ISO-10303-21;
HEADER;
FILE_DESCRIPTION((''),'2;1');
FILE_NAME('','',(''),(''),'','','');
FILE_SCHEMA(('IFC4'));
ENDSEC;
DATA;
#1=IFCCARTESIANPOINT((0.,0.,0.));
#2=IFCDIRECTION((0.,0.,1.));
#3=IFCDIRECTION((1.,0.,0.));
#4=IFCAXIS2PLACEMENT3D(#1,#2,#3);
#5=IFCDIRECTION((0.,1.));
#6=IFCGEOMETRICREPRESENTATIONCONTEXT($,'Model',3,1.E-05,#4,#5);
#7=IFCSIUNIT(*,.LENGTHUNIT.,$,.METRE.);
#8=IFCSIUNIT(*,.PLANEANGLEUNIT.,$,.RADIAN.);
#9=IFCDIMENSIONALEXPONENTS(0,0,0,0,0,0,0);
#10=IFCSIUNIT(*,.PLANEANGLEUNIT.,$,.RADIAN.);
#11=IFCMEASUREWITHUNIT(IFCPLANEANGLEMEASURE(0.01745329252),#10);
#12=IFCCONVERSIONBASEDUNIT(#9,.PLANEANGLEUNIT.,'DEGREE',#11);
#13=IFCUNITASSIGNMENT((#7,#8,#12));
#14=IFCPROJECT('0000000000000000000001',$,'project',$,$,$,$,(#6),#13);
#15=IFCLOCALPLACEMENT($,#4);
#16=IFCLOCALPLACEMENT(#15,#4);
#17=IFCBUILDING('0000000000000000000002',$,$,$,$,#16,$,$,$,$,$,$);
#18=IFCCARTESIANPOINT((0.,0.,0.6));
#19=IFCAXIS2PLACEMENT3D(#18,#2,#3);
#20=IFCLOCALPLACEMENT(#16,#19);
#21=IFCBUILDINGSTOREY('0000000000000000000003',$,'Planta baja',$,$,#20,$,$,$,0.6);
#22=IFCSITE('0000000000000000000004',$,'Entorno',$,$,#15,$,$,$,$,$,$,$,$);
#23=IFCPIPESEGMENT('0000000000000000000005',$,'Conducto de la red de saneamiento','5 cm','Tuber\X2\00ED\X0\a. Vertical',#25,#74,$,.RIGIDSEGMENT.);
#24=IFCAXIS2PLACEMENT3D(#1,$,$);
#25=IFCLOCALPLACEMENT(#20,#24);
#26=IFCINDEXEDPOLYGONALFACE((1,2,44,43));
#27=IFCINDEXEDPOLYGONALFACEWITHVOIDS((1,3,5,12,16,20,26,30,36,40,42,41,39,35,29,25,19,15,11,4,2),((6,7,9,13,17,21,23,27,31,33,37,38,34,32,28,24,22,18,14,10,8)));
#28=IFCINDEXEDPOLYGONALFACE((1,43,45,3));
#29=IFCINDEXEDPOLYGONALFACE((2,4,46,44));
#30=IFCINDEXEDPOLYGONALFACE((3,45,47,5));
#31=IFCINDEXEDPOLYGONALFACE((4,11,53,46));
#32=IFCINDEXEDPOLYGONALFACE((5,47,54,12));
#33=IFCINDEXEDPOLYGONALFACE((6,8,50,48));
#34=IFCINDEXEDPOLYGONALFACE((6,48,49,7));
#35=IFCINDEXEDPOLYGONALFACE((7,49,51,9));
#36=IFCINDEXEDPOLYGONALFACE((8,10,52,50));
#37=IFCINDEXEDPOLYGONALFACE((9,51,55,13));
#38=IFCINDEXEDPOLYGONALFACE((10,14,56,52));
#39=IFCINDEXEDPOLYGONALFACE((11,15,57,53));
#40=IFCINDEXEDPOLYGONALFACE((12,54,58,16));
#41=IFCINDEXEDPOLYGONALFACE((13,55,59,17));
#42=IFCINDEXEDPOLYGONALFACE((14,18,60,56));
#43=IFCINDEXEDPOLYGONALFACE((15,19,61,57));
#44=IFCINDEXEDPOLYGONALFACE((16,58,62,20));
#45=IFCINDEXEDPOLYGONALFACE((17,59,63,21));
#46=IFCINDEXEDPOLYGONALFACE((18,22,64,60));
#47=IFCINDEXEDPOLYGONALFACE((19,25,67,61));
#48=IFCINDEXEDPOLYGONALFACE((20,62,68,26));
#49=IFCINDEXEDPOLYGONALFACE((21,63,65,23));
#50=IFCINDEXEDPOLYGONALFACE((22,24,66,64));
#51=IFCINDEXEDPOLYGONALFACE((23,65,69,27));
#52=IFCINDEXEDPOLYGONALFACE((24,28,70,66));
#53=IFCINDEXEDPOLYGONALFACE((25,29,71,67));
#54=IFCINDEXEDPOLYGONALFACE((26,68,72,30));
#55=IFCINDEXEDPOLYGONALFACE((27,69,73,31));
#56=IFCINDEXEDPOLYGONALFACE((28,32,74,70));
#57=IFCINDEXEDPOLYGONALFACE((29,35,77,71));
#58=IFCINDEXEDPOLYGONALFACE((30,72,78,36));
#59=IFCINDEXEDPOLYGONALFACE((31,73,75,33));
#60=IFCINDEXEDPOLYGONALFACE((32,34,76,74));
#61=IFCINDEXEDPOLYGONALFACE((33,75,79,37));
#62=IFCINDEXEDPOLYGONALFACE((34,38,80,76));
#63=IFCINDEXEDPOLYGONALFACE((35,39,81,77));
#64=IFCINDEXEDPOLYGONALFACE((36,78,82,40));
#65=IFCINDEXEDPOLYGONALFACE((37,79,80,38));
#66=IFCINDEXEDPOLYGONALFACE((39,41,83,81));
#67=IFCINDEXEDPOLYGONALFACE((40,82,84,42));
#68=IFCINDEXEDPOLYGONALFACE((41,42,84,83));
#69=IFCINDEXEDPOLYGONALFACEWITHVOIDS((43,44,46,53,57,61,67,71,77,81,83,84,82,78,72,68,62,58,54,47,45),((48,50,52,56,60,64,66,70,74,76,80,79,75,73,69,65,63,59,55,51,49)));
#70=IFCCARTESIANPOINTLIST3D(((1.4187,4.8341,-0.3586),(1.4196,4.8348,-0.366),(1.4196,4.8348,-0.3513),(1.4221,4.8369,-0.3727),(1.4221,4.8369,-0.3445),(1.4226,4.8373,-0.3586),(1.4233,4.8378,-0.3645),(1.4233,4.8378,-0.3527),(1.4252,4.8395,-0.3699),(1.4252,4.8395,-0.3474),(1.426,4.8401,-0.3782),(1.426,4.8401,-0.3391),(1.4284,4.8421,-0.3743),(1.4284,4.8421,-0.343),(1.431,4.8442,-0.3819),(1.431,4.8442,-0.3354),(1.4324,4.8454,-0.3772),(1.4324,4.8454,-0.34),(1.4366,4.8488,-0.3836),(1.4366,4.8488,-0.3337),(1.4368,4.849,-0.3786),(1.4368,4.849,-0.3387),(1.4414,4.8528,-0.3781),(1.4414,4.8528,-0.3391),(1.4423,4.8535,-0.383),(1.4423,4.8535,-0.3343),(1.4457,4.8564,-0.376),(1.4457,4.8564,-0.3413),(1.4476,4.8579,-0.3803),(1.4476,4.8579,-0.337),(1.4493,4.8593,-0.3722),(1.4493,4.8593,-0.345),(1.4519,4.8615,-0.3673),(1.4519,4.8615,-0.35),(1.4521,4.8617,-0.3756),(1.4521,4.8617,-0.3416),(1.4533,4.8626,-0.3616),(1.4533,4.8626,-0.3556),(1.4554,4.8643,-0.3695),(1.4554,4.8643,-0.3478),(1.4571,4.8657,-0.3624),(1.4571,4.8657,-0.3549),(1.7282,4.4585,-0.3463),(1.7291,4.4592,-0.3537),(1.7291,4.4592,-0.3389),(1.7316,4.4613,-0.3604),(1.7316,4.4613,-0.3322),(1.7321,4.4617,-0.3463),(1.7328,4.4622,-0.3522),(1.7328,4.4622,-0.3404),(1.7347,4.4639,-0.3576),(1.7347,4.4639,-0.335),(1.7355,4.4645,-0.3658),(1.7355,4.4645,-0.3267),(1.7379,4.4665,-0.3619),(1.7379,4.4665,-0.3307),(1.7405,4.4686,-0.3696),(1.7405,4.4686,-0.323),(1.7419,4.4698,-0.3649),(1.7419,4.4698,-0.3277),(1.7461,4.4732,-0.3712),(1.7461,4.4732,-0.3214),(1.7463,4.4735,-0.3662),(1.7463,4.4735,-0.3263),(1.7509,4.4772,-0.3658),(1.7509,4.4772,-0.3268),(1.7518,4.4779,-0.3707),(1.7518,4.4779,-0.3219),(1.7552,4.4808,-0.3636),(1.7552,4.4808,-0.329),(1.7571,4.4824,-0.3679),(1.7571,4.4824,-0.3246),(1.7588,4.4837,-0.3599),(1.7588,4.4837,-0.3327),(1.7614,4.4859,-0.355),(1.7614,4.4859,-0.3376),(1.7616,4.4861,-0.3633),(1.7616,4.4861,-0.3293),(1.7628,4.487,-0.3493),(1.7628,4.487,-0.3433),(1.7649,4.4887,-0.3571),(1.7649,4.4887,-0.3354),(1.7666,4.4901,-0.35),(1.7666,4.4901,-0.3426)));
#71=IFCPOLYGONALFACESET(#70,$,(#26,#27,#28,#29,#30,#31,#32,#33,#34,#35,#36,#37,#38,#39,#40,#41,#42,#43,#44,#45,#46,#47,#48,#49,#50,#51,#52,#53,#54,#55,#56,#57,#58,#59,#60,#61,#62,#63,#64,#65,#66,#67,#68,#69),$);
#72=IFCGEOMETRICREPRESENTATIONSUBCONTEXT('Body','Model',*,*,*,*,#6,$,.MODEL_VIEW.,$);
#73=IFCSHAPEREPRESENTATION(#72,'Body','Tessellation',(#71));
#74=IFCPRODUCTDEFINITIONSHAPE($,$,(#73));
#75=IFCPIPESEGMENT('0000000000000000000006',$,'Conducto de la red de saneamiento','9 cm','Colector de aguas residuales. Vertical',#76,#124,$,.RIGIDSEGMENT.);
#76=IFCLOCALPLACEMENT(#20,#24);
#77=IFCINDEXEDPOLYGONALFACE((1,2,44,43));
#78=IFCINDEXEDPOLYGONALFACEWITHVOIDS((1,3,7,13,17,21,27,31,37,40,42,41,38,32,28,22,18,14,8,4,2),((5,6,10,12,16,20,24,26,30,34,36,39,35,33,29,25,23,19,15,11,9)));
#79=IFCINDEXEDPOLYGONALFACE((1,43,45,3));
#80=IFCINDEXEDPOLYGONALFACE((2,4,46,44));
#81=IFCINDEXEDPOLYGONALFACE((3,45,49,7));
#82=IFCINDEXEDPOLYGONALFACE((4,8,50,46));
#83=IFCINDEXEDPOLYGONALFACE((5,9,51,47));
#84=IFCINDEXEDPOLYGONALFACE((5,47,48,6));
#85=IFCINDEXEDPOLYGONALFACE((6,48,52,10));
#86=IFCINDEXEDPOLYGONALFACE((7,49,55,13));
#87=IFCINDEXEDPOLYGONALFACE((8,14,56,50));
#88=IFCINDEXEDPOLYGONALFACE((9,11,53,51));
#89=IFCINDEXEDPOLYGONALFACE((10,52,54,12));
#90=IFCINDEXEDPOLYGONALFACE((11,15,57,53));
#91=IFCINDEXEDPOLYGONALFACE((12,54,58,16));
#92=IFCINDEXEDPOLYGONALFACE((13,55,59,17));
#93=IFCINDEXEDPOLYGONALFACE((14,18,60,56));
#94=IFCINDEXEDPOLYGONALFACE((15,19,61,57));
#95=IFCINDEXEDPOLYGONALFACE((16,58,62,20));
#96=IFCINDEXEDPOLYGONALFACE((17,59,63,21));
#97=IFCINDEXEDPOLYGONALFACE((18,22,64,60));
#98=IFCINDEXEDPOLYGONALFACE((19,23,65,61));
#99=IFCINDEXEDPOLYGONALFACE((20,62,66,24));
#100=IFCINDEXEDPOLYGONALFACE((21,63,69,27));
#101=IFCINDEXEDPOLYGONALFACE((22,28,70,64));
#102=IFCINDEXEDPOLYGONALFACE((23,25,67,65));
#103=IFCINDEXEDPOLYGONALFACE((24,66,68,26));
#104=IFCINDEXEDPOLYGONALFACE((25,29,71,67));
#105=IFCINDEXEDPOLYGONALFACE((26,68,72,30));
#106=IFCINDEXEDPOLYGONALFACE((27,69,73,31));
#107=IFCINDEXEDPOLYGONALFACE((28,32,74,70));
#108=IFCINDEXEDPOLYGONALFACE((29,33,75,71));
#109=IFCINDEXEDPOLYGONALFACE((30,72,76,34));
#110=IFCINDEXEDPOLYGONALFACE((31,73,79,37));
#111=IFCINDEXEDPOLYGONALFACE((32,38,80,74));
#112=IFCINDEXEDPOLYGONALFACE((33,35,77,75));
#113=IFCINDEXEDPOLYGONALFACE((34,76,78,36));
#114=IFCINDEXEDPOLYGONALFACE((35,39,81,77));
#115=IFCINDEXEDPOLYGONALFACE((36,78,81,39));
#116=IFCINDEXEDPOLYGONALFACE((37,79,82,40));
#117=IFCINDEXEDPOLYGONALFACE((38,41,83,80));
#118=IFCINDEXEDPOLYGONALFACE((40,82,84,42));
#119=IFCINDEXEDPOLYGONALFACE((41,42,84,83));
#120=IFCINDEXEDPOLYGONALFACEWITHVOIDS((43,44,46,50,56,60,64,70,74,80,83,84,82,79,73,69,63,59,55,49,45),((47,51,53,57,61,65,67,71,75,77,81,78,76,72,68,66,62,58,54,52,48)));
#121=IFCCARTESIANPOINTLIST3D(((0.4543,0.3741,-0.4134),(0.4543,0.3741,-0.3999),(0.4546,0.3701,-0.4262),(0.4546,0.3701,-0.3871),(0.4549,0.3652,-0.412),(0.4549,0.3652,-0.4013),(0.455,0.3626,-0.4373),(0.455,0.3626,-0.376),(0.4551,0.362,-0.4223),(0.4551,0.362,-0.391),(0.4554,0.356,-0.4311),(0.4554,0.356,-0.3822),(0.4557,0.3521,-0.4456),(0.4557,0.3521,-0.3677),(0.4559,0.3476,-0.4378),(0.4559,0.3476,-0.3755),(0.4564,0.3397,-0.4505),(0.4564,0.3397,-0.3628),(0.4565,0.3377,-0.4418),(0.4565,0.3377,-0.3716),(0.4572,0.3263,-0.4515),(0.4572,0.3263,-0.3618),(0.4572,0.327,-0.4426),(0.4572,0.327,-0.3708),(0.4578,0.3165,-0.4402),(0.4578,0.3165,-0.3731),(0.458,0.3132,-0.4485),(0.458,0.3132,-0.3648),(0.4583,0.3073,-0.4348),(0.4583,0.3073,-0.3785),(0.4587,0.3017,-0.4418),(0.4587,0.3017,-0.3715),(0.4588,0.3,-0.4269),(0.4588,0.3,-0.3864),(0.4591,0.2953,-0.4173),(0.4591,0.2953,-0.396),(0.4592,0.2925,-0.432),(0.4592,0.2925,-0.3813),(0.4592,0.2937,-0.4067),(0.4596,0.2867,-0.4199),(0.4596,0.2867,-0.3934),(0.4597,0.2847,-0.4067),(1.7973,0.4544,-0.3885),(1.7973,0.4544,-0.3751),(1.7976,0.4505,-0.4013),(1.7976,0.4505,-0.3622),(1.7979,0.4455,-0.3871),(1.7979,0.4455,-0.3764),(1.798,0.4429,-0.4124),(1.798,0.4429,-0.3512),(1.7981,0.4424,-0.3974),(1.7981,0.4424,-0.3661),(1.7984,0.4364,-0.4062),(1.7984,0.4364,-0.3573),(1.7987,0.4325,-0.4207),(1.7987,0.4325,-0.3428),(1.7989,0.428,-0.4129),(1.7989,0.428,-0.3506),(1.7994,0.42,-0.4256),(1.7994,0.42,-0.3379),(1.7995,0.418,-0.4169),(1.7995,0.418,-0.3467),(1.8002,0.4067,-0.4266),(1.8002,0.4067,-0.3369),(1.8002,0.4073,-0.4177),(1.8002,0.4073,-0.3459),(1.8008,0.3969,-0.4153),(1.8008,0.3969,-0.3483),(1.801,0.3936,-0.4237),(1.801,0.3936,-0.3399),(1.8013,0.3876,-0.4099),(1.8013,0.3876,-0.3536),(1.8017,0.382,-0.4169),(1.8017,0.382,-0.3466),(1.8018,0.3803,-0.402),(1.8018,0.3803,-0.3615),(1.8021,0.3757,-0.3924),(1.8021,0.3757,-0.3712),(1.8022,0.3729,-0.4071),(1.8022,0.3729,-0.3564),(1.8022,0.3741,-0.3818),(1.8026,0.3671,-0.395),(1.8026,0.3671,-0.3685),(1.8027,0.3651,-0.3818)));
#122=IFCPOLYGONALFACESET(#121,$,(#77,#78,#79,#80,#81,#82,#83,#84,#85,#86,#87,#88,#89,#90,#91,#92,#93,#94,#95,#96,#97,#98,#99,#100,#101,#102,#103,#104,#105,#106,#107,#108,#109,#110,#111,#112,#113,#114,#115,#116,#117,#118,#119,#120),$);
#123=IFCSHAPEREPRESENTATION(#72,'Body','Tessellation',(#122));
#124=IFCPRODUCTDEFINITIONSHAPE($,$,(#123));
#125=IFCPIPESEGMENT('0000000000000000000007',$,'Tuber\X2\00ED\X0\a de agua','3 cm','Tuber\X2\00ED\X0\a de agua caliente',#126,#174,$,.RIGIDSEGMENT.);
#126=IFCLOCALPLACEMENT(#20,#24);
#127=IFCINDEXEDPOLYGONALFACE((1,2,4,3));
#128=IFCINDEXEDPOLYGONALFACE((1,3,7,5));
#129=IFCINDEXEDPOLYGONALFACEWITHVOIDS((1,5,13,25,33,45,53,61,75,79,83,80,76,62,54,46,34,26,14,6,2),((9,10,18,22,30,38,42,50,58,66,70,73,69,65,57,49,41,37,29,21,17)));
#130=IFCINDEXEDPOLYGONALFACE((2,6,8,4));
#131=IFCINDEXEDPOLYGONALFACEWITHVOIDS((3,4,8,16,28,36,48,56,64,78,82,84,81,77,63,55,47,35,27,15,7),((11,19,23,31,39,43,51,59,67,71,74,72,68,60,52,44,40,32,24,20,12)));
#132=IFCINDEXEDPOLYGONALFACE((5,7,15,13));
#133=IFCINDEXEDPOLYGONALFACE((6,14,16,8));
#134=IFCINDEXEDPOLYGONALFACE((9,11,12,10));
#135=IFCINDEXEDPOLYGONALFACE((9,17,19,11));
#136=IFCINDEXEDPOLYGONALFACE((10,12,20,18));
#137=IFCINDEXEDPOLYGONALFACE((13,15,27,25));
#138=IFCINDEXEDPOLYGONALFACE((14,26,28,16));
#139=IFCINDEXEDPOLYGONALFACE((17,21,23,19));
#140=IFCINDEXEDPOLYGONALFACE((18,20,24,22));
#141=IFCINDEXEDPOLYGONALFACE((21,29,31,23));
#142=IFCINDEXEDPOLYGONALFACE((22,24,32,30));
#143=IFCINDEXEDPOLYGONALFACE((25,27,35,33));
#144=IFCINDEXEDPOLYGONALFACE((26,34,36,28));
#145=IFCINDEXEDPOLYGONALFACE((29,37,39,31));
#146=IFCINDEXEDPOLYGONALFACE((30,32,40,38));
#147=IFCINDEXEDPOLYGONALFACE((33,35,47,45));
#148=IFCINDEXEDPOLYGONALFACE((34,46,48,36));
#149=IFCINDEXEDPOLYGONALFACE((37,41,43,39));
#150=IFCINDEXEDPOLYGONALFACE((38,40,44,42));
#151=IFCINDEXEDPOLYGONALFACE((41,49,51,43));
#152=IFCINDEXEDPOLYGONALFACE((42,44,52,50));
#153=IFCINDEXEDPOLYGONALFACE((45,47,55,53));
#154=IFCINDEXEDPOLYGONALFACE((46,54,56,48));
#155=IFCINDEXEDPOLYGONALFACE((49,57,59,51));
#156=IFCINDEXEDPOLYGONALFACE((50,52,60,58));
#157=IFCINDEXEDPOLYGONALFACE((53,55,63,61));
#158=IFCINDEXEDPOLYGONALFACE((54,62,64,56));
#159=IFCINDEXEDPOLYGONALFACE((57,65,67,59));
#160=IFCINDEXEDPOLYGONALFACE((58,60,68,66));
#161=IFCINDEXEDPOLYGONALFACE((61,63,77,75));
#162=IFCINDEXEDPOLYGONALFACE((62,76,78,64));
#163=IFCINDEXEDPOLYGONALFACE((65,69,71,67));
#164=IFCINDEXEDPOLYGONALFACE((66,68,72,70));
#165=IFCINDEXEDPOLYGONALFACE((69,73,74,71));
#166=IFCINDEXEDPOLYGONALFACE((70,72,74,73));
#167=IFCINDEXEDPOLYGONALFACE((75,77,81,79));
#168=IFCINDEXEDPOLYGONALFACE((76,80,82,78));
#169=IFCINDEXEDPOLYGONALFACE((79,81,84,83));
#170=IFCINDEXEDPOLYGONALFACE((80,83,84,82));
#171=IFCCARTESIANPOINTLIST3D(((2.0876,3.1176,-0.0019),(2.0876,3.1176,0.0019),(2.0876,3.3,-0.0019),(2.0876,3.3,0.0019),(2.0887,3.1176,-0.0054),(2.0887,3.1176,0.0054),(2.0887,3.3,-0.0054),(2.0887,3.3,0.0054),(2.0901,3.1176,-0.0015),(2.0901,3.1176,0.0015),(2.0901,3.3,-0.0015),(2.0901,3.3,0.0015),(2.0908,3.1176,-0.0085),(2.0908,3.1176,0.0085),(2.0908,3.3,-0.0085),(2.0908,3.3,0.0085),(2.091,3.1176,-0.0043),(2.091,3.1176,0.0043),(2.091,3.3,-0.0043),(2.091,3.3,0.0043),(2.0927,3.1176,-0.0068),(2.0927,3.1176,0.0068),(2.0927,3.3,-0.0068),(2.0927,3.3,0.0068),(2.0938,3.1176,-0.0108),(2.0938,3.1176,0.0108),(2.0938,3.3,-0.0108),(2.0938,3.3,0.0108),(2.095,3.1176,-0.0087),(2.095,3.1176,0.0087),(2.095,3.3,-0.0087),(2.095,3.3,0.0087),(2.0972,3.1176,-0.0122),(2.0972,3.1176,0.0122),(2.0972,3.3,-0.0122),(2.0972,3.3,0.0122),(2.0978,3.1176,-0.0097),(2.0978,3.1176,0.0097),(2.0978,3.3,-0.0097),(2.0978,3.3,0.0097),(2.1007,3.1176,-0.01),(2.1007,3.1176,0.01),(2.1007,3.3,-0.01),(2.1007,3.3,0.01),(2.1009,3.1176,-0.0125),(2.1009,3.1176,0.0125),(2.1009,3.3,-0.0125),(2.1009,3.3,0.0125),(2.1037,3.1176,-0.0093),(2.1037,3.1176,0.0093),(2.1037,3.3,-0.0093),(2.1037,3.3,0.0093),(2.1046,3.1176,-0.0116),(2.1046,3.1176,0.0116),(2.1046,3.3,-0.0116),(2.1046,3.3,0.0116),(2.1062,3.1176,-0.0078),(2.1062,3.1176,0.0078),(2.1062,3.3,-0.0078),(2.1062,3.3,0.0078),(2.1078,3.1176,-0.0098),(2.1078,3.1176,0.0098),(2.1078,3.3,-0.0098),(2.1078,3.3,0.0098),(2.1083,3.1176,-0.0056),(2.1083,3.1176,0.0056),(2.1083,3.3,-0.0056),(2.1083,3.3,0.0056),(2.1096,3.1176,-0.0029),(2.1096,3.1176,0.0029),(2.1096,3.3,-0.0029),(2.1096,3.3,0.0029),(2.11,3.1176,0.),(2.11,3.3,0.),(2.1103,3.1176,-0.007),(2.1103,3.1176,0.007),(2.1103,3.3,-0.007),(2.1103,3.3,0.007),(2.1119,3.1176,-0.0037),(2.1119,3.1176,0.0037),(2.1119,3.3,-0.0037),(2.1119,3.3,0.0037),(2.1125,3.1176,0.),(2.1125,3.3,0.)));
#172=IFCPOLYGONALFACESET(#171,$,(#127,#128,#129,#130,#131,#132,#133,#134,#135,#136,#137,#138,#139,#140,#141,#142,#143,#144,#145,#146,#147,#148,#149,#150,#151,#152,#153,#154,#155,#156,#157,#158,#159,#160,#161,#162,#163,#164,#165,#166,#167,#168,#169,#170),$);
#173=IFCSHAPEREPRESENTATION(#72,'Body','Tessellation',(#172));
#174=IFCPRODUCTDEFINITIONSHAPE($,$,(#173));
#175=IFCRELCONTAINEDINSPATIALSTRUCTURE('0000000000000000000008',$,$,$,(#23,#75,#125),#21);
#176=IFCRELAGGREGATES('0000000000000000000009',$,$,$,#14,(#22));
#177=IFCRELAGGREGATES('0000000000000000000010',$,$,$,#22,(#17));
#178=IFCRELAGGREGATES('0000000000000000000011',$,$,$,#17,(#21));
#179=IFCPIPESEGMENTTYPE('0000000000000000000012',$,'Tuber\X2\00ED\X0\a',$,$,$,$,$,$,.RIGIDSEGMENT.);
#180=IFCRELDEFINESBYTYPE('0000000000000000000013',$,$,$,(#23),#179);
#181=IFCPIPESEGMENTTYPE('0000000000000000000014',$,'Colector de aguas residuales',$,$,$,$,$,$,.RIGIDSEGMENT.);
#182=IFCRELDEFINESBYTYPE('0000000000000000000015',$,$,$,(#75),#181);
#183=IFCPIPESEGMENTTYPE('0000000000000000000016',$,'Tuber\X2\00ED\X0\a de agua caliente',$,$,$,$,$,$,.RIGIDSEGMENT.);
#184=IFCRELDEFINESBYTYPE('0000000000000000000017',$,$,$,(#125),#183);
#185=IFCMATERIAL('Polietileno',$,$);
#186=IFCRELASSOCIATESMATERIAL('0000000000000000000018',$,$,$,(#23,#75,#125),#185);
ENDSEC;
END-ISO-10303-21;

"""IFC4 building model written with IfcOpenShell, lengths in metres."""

from ifc_helpers import new_model, entity, si_unit, converted_unit, direction, frame, origin_with_axes, origin_2d_with_axis, place, context, subcontext, project, spatial, hollow_circle, extrude, material, type_object, element, save


model = new_model("IFC4")

# Units and contexts
model_context = context("Model", 3, precision=1e-05, world=origin_with_axes(), true_north=direction((0.0, 1.0)))
body_context = subcontext(model_context, "Body", "Model", "MODEL_VIEW")
ifc_project = project(units=[si_unit("LENGTHUNIT", "METRE"), si_unit("PLANEANGLEUNIT", "RADIAN"), converted_unit("PLANEANGLEUNIT", "DEGREE", entity("IfcPlaneAngleMeasure", 0.01745329252), si_unit("PLANEANGLEUNIT", "RADIAN"), dimensions=[0, 0, 0, 0, 0, 0, 0])], contexts=[model_context])

# Site, building, storey
site_placement = place(None, origin_with_axes())
site = spatial("IfcSite", under=ifc_project, at=site_placement, Name="Entorno")
building_placement = place(site_placement, origin_with_axes())
building = spatial("IfcBuilding", under=site, at=building_placement)
storey_placement = place(building_placement, frame((0.0, 0.0, 0.6), z_axis=(0.0, 0.0, 1.0), x_axis=(1.0, 0.0, 0.0)))
storey = spatial("IfcBuildingStorey", under=building, at=storey_placement, Name="Planta baja", Elevation=0.6)

# Shared definitions
ifc_material_1 = material(Name="Polietileno")

# Pipe segments
pipe_segment_type_1 = type_object("IfcPipeSegmentType", Name="Tubería", PredefinedType="RIGIDSEGMENT")
pipe_segment_1_placement = place(storey_placement, frame((1.7475, 4.4744, -0.3463), z_axis=(-0.635934, 0.771743, 0.0), x_axis=(-0.771743, -0.635934, 0.0)))
element("IfcPipeSegment", 1, at=pipe_segment_1_placement, inside=storey, type_object=pipe_segment_type_1, material=ifc_material_1, Name="Conducto de la red de saneamiento", Description="5 cm", ObjectType="Tubería. Vertical", PredefinedType="RIGIDSEGMENT", context=body_context, shape_type="SweptSolid", body=[
    extrude(hollow_circle(Radius=0.025, WallThickness=0.005, at=origin_2d_with_axis()), origin_with_axes(), (0.0, -0.025339, 0.999679), 0.4868),
])
pipe_segment_type_2 = type_object("IfcPipeSegmentType", Name="Colector de aguas residuales", PredefinedType="RIGIDSEGMENT")
pipe_segment_2_placement = place(storey_placement, frame((1.8, 0.41, -0.3818), z_axis=(-0.998215, -0.059724, 0.0), x_axis=(0.059724, -0.998215, 0.0)))
element("IfcPipeSegment", 2, at=pipe_segment_2_placement, inside=storey, type_object=pipe_segment_type_2, material=ifc_material_1, Name="Conducto de la red de saneamiento", Description="9 cm", ObjectType="Colector de aguas residuales. Vertical", PredefinedType="RIGIDSEGMENT", context=body_context, shape_type="SweptSolid", body=[
    extrude(hollow_circle(Radius=0.045, WallThickness=0.009, at=origin_2d_with_axis()), origin_with_axes(), (0.0, -0.018497, 0.999829), 1.3456),
])
pipe_segment_type_3 = type_object("IfcPipeSegmentType", Name="Tubería de agua caliente", PredefinedType="RIGIDSEGMENT")
pipe_segment_3_placement = place(storey_placement, frame((2.1, 3.3, 0.0), z_axis=(0.0, -1.0, 0.0), x_axis=(1.0, 0.0, 0.0)))
element("IfcPipeSegment", 3, at=pipe_segment_3_placement, inside=storey, type_object=pipe_segment_type_3, material=ifc_material_1, Name="Tubería de agua", Description="3 cm", ObjectType="Tubería de agua caliente", PredefinedType="RIGIDSEGMENT", context=body_context, shape_type="SweptSolid", body=[
    extrude(hollow_circle(Radius=0.0125, WallThickness=0.0025, at=origin_2d_with_axis()), origin_with_axes(), (0.0, 0.0, 1.0), 0.1824),
])

save(model, "model.ifc")
